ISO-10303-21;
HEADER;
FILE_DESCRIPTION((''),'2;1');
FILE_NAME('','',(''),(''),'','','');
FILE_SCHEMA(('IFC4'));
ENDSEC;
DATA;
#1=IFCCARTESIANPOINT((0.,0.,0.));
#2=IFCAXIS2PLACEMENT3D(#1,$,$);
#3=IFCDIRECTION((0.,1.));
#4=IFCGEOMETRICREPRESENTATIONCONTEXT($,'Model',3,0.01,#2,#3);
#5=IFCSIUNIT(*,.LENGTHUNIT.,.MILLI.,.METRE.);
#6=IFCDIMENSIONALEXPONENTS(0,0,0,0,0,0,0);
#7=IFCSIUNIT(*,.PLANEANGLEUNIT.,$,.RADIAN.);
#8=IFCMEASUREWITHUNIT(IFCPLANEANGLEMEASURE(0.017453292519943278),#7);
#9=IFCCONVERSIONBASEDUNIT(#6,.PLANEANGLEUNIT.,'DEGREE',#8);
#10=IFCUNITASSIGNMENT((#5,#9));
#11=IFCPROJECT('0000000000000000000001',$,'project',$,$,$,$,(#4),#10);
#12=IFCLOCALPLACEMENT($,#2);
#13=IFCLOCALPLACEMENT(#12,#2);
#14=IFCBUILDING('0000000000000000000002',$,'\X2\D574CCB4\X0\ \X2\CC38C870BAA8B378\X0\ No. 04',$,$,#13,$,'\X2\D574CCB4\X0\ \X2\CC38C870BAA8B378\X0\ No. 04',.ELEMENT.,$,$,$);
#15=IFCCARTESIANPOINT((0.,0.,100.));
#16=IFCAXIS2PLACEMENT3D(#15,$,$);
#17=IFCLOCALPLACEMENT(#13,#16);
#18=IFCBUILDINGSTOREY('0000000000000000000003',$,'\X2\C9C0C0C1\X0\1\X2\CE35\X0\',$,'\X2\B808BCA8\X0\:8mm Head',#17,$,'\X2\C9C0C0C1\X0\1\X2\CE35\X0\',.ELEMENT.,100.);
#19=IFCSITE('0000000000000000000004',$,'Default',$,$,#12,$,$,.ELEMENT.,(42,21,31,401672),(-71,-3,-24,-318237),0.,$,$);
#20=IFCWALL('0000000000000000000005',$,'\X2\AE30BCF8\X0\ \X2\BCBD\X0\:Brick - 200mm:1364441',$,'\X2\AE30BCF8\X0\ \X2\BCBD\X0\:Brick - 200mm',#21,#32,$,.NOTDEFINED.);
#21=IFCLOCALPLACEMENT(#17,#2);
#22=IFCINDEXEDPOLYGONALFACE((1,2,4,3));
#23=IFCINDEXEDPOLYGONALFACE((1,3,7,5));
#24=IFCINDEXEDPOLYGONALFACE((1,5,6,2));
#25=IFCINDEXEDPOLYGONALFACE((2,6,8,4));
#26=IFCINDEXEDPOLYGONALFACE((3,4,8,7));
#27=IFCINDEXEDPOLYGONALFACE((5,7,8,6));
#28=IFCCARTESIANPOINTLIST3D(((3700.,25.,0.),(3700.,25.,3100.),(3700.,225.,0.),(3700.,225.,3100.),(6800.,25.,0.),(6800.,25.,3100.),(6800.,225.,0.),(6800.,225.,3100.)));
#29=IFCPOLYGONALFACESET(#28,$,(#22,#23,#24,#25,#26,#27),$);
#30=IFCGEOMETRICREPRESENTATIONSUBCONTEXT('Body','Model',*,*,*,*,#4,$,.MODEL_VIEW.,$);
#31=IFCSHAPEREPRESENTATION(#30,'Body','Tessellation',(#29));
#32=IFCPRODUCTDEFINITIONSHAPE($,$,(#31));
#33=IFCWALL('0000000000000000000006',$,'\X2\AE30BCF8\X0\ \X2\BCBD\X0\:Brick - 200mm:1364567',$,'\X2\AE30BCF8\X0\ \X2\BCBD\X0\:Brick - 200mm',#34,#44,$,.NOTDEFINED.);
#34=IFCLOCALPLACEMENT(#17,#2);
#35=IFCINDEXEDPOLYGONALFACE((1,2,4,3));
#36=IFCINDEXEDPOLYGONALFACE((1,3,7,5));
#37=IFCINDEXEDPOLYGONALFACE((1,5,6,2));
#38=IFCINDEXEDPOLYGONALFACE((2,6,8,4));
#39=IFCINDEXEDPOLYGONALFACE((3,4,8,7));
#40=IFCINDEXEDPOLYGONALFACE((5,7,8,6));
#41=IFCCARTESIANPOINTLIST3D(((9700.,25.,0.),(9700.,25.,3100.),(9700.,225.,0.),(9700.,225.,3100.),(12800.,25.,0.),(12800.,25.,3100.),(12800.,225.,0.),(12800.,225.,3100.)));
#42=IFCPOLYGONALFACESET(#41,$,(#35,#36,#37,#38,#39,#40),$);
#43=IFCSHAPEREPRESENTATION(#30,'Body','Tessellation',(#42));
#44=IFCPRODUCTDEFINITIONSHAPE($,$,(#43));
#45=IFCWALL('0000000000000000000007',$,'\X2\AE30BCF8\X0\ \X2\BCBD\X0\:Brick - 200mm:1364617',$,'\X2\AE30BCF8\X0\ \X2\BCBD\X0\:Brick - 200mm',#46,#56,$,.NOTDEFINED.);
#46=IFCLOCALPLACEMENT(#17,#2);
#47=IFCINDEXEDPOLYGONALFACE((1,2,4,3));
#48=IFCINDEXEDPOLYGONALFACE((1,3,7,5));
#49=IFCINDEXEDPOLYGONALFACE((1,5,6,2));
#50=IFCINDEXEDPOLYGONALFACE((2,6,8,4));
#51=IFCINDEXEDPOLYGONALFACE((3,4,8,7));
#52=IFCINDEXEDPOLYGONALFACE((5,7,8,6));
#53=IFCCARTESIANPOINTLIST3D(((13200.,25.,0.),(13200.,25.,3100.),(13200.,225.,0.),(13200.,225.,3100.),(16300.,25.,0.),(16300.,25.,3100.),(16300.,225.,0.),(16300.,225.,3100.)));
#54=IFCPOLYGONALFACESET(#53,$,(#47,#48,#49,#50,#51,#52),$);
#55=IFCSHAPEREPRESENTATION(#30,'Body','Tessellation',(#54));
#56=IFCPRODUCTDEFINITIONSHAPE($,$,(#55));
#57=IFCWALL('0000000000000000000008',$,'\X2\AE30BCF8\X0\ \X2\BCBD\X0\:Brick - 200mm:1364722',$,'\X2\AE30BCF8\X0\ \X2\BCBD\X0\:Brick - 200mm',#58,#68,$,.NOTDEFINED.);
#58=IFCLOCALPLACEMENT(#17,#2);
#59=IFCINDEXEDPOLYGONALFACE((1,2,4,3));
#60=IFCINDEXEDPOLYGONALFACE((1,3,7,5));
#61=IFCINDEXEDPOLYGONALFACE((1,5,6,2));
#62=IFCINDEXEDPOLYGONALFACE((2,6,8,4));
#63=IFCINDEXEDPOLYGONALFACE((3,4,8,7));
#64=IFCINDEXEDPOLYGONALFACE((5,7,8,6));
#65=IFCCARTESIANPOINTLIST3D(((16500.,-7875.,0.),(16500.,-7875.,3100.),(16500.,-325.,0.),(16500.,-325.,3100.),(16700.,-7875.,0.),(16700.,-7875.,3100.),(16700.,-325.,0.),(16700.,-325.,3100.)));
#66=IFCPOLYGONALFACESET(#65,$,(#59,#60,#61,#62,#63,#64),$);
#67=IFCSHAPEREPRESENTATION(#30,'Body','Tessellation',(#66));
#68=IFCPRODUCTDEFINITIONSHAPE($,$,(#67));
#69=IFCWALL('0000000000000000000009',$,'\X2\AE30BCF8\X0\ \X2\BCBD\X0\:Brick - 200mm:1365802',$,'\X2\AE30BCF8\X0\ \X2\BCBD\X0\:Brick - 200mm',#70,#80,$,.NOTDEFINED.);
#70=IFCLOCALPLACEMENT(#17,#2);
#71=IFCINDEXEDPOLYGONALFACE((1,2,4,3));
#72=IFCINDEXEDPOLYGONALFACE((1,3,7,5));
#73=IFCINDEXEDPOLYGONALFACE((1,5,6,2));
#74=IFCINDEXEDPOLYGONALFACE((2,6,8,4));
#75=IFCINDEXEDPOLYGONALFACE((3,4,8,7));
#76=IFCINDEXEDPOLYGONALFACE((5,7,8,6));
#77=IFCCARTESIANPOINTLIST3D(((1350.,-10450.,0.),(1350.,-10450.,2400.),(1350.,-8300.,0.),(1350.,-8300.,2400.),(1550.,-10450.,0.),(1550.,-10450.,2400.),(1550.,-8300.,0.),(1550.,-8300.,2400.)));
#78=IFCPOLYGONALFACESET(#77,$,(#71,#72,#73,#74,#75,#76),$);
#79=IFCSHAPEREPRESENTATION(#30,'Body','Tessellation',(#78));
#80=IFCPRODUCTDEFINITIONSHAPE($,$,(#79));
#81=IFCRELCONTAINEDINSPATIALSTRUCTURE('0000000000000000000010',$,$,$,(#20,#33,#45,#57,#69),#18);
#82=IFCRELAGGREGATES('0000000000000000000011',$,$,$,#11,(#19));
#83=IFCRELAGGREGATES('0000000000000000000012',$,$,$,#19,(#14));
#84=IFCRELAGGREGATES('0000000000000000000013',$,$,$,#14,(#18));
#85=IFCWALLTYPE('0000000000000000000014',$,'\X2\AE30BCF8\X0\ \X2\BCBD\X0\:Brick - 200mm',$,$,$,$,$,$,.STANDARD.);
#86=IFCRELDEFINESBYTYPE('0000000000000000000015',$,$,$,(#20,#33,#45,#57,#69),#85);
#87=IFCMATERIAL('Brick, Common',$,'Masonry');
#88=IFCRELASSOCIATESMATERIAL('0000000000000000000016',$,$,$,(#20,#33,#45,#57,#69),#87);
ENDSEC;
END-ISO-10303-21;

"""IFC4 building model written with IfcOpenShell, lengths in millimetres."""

from ifc_helpers import new_model, entity, si_unit, converted_unit, direction, frame, origin, place, context, subcontext, project, spatial, indexed_curve, outline, extrude, material, type_object, element, save


model = new_model("IFC4")

# Units and contexts
model_context = context("Model", 3, precision=0.01, world=origin(), true_north=direction((0.0, 1.0)))
body_context = subcontext(model_context, "Body", "Model", "MODEL_VIEW")
ifc_project = project(units=[si_unit("LENGTHUNIT", "METRE", prefix="MILLI"), converted_unit("PLANEANGLEUNIT", "DEGREE", entity("IfcPlaneAngleMeasure", 0.017453292519943278), si_unit("PLANEANGLEUNIT", "RADIAN"), dimensions=[0, 0, 0, 0, 0, 0, 0])], contexts=[model_context])

# Site, building, storey
site_placement = place(None, origin())
site = spatial("IfcSite", under=ifc_project, at=site_placement, Name="Default", CompositionType="ELEMENT", RefLatitude=(42, 21, 31, 401672), RefLongitude=(-71, -3, -24, -318237), RefElevation=0.0)
building_placement = place(site_placement, origin())
building = spatial("IfcBuilding", under=site, at=building_placement, Name="해체 참조모델 No. 04", LongName="해체 참조모델 No. 04", CompositionType="ELEMENT")
storey_placement = place(building_placement, frame((0.0, 0.0, 100.0)))
storey = spatial("IfcBuildingStorey", under=building, at=storey_placement, Name="지상1층", ObjectType="레벨:8mm Head", LongName="지상1층", CompositionType="ELEMENT", Elevation=100.0)

# Walls
ifc_material_1 = material(Name="Brick, Common", Category="Masonry")
wall_type = type_object("IfcWallType", Name="기본 벽:Brick - 200mm", PredefinedType="STANDARD")
wall_1_placement = place(storey_placement, frame((3700.0, 125.0, 0.0)))
element("IfcWall", 1, at=wall_1_placement, inside=storey, type_object=wall_type, material=ifc_material_1, Name="기본 벽:Brick - 200mm:1364441", ObjectType="기본 벽:Brick - 200mm", PredefinedType="NOTDEFINED", context=body_context, shape_type="SweptSolid", body=[
    extrude(outline(indexed_curve([(3100.0, 100.0), (0.0, 100.0), (0.0, -100.0), (3100.0, -100.0), (3100.0, 100.0)], self_intersect=False)), origin(), (0.0, 0.0, 1.0), 3100.0),
])
wall_2_placement = place(storey_placement, frame((9700.0, 125.0, 0.0)))
element("IfcWall", 2, at=wall_2_placement, inside=storey, type_object=wall_type, material=ifc_material_1, Name="기본 벽:Brick - 200mm:1364567", ObjectType="기본 벽:Brick - 200mm", PredefinedType="NOTDEFINED", context=body_context, shape_type="SweptSolid", body=[
    extrude(outline(indexed_curve([(3100.0, 100.0), (0.0, 100.0), (0.0, -100.0), (3100.0, -100.0), (3100.0, 100.0)], self_intersect=False)), origin(), (0.0, 0.0, 1.0), 3100.0),
])
wall_3_placement = place(storey_placement, frame((13200.0, 125.0, 0.0)))
element("IfcWall", 3, at=wall_3_placement, inside=storey, type_object=wall_type, material=ifc_material_1, Name="기본 벽:Brick - 200mm:1364617", ObjectType="기본 벽:Brick - 200mm", PredefinedType="NOTDEFINED", context=body_context, shape_type="SweptSolid", body=[
    extrude(outline(indexed_curve([(3100.0, 100.0), (0.0, 100.0), (0.0, -100.0), (3100.0, -100.0), (3100.0, 100.0)], self_intersect=False)), origin(), (0.0, 0.0, 1.0), 3100.0),
])
wall_4_placement = place(storey_placement, frame((16600.0, -325.0, 0.0), z_axis=(0.0, 0.0, 1.0), x_axis=(0.0, -1.0, 0.0)))
element("IfcWall", 4, at=wall_4_placement, inside=storey, type_object=wall_type, material=ifc_material_1, Name="기본 벽:Brick - 200mm:1364722", ObjectType="기본 벽:Brick - 200mm", PredefinedType="NOTDEFINED", context=body_context, shape_type="SweptSolid", body=[
    extrude(outline(indexed_curve([(7550.0, 100.0), (0.0, 100.0), (0.0, -100.0), (7550.0, -100.0), (7550.0, 100.0)], self_intersect=False)), origin(), (0.0, 0.0, 1.0), 3100.0),
])
wall_5_placement = place(storey_placement, frame((1450.0, -8300.0, 0.0), z_axis=(0.0, 0.0, 1.0), x_axis=(0.0, -1.0, 0.0)))
element("IfcWall", 5, at=wall_5_placement, inside=storey, type_object=wall_type, material=ifc_material_1, Name="기본 벽:Brick - 200mm:1365802", ObjectType="기본 벽:Brick - 200mm", PredefinedType="NOTDEFINED", context=body_context, shape_type="SweptSolid", body=[
    extrude(outline(indexed_curve([(2150.0, 100.0), (0.0, 100.0), (0.0, -100.0), (2150.0, -100.0), (2150.0, 100.0)], self_intersect=False)), origin(), (0.0, 0.0, 1.0), 2400.0),
])

save(model, "model.ifc")
